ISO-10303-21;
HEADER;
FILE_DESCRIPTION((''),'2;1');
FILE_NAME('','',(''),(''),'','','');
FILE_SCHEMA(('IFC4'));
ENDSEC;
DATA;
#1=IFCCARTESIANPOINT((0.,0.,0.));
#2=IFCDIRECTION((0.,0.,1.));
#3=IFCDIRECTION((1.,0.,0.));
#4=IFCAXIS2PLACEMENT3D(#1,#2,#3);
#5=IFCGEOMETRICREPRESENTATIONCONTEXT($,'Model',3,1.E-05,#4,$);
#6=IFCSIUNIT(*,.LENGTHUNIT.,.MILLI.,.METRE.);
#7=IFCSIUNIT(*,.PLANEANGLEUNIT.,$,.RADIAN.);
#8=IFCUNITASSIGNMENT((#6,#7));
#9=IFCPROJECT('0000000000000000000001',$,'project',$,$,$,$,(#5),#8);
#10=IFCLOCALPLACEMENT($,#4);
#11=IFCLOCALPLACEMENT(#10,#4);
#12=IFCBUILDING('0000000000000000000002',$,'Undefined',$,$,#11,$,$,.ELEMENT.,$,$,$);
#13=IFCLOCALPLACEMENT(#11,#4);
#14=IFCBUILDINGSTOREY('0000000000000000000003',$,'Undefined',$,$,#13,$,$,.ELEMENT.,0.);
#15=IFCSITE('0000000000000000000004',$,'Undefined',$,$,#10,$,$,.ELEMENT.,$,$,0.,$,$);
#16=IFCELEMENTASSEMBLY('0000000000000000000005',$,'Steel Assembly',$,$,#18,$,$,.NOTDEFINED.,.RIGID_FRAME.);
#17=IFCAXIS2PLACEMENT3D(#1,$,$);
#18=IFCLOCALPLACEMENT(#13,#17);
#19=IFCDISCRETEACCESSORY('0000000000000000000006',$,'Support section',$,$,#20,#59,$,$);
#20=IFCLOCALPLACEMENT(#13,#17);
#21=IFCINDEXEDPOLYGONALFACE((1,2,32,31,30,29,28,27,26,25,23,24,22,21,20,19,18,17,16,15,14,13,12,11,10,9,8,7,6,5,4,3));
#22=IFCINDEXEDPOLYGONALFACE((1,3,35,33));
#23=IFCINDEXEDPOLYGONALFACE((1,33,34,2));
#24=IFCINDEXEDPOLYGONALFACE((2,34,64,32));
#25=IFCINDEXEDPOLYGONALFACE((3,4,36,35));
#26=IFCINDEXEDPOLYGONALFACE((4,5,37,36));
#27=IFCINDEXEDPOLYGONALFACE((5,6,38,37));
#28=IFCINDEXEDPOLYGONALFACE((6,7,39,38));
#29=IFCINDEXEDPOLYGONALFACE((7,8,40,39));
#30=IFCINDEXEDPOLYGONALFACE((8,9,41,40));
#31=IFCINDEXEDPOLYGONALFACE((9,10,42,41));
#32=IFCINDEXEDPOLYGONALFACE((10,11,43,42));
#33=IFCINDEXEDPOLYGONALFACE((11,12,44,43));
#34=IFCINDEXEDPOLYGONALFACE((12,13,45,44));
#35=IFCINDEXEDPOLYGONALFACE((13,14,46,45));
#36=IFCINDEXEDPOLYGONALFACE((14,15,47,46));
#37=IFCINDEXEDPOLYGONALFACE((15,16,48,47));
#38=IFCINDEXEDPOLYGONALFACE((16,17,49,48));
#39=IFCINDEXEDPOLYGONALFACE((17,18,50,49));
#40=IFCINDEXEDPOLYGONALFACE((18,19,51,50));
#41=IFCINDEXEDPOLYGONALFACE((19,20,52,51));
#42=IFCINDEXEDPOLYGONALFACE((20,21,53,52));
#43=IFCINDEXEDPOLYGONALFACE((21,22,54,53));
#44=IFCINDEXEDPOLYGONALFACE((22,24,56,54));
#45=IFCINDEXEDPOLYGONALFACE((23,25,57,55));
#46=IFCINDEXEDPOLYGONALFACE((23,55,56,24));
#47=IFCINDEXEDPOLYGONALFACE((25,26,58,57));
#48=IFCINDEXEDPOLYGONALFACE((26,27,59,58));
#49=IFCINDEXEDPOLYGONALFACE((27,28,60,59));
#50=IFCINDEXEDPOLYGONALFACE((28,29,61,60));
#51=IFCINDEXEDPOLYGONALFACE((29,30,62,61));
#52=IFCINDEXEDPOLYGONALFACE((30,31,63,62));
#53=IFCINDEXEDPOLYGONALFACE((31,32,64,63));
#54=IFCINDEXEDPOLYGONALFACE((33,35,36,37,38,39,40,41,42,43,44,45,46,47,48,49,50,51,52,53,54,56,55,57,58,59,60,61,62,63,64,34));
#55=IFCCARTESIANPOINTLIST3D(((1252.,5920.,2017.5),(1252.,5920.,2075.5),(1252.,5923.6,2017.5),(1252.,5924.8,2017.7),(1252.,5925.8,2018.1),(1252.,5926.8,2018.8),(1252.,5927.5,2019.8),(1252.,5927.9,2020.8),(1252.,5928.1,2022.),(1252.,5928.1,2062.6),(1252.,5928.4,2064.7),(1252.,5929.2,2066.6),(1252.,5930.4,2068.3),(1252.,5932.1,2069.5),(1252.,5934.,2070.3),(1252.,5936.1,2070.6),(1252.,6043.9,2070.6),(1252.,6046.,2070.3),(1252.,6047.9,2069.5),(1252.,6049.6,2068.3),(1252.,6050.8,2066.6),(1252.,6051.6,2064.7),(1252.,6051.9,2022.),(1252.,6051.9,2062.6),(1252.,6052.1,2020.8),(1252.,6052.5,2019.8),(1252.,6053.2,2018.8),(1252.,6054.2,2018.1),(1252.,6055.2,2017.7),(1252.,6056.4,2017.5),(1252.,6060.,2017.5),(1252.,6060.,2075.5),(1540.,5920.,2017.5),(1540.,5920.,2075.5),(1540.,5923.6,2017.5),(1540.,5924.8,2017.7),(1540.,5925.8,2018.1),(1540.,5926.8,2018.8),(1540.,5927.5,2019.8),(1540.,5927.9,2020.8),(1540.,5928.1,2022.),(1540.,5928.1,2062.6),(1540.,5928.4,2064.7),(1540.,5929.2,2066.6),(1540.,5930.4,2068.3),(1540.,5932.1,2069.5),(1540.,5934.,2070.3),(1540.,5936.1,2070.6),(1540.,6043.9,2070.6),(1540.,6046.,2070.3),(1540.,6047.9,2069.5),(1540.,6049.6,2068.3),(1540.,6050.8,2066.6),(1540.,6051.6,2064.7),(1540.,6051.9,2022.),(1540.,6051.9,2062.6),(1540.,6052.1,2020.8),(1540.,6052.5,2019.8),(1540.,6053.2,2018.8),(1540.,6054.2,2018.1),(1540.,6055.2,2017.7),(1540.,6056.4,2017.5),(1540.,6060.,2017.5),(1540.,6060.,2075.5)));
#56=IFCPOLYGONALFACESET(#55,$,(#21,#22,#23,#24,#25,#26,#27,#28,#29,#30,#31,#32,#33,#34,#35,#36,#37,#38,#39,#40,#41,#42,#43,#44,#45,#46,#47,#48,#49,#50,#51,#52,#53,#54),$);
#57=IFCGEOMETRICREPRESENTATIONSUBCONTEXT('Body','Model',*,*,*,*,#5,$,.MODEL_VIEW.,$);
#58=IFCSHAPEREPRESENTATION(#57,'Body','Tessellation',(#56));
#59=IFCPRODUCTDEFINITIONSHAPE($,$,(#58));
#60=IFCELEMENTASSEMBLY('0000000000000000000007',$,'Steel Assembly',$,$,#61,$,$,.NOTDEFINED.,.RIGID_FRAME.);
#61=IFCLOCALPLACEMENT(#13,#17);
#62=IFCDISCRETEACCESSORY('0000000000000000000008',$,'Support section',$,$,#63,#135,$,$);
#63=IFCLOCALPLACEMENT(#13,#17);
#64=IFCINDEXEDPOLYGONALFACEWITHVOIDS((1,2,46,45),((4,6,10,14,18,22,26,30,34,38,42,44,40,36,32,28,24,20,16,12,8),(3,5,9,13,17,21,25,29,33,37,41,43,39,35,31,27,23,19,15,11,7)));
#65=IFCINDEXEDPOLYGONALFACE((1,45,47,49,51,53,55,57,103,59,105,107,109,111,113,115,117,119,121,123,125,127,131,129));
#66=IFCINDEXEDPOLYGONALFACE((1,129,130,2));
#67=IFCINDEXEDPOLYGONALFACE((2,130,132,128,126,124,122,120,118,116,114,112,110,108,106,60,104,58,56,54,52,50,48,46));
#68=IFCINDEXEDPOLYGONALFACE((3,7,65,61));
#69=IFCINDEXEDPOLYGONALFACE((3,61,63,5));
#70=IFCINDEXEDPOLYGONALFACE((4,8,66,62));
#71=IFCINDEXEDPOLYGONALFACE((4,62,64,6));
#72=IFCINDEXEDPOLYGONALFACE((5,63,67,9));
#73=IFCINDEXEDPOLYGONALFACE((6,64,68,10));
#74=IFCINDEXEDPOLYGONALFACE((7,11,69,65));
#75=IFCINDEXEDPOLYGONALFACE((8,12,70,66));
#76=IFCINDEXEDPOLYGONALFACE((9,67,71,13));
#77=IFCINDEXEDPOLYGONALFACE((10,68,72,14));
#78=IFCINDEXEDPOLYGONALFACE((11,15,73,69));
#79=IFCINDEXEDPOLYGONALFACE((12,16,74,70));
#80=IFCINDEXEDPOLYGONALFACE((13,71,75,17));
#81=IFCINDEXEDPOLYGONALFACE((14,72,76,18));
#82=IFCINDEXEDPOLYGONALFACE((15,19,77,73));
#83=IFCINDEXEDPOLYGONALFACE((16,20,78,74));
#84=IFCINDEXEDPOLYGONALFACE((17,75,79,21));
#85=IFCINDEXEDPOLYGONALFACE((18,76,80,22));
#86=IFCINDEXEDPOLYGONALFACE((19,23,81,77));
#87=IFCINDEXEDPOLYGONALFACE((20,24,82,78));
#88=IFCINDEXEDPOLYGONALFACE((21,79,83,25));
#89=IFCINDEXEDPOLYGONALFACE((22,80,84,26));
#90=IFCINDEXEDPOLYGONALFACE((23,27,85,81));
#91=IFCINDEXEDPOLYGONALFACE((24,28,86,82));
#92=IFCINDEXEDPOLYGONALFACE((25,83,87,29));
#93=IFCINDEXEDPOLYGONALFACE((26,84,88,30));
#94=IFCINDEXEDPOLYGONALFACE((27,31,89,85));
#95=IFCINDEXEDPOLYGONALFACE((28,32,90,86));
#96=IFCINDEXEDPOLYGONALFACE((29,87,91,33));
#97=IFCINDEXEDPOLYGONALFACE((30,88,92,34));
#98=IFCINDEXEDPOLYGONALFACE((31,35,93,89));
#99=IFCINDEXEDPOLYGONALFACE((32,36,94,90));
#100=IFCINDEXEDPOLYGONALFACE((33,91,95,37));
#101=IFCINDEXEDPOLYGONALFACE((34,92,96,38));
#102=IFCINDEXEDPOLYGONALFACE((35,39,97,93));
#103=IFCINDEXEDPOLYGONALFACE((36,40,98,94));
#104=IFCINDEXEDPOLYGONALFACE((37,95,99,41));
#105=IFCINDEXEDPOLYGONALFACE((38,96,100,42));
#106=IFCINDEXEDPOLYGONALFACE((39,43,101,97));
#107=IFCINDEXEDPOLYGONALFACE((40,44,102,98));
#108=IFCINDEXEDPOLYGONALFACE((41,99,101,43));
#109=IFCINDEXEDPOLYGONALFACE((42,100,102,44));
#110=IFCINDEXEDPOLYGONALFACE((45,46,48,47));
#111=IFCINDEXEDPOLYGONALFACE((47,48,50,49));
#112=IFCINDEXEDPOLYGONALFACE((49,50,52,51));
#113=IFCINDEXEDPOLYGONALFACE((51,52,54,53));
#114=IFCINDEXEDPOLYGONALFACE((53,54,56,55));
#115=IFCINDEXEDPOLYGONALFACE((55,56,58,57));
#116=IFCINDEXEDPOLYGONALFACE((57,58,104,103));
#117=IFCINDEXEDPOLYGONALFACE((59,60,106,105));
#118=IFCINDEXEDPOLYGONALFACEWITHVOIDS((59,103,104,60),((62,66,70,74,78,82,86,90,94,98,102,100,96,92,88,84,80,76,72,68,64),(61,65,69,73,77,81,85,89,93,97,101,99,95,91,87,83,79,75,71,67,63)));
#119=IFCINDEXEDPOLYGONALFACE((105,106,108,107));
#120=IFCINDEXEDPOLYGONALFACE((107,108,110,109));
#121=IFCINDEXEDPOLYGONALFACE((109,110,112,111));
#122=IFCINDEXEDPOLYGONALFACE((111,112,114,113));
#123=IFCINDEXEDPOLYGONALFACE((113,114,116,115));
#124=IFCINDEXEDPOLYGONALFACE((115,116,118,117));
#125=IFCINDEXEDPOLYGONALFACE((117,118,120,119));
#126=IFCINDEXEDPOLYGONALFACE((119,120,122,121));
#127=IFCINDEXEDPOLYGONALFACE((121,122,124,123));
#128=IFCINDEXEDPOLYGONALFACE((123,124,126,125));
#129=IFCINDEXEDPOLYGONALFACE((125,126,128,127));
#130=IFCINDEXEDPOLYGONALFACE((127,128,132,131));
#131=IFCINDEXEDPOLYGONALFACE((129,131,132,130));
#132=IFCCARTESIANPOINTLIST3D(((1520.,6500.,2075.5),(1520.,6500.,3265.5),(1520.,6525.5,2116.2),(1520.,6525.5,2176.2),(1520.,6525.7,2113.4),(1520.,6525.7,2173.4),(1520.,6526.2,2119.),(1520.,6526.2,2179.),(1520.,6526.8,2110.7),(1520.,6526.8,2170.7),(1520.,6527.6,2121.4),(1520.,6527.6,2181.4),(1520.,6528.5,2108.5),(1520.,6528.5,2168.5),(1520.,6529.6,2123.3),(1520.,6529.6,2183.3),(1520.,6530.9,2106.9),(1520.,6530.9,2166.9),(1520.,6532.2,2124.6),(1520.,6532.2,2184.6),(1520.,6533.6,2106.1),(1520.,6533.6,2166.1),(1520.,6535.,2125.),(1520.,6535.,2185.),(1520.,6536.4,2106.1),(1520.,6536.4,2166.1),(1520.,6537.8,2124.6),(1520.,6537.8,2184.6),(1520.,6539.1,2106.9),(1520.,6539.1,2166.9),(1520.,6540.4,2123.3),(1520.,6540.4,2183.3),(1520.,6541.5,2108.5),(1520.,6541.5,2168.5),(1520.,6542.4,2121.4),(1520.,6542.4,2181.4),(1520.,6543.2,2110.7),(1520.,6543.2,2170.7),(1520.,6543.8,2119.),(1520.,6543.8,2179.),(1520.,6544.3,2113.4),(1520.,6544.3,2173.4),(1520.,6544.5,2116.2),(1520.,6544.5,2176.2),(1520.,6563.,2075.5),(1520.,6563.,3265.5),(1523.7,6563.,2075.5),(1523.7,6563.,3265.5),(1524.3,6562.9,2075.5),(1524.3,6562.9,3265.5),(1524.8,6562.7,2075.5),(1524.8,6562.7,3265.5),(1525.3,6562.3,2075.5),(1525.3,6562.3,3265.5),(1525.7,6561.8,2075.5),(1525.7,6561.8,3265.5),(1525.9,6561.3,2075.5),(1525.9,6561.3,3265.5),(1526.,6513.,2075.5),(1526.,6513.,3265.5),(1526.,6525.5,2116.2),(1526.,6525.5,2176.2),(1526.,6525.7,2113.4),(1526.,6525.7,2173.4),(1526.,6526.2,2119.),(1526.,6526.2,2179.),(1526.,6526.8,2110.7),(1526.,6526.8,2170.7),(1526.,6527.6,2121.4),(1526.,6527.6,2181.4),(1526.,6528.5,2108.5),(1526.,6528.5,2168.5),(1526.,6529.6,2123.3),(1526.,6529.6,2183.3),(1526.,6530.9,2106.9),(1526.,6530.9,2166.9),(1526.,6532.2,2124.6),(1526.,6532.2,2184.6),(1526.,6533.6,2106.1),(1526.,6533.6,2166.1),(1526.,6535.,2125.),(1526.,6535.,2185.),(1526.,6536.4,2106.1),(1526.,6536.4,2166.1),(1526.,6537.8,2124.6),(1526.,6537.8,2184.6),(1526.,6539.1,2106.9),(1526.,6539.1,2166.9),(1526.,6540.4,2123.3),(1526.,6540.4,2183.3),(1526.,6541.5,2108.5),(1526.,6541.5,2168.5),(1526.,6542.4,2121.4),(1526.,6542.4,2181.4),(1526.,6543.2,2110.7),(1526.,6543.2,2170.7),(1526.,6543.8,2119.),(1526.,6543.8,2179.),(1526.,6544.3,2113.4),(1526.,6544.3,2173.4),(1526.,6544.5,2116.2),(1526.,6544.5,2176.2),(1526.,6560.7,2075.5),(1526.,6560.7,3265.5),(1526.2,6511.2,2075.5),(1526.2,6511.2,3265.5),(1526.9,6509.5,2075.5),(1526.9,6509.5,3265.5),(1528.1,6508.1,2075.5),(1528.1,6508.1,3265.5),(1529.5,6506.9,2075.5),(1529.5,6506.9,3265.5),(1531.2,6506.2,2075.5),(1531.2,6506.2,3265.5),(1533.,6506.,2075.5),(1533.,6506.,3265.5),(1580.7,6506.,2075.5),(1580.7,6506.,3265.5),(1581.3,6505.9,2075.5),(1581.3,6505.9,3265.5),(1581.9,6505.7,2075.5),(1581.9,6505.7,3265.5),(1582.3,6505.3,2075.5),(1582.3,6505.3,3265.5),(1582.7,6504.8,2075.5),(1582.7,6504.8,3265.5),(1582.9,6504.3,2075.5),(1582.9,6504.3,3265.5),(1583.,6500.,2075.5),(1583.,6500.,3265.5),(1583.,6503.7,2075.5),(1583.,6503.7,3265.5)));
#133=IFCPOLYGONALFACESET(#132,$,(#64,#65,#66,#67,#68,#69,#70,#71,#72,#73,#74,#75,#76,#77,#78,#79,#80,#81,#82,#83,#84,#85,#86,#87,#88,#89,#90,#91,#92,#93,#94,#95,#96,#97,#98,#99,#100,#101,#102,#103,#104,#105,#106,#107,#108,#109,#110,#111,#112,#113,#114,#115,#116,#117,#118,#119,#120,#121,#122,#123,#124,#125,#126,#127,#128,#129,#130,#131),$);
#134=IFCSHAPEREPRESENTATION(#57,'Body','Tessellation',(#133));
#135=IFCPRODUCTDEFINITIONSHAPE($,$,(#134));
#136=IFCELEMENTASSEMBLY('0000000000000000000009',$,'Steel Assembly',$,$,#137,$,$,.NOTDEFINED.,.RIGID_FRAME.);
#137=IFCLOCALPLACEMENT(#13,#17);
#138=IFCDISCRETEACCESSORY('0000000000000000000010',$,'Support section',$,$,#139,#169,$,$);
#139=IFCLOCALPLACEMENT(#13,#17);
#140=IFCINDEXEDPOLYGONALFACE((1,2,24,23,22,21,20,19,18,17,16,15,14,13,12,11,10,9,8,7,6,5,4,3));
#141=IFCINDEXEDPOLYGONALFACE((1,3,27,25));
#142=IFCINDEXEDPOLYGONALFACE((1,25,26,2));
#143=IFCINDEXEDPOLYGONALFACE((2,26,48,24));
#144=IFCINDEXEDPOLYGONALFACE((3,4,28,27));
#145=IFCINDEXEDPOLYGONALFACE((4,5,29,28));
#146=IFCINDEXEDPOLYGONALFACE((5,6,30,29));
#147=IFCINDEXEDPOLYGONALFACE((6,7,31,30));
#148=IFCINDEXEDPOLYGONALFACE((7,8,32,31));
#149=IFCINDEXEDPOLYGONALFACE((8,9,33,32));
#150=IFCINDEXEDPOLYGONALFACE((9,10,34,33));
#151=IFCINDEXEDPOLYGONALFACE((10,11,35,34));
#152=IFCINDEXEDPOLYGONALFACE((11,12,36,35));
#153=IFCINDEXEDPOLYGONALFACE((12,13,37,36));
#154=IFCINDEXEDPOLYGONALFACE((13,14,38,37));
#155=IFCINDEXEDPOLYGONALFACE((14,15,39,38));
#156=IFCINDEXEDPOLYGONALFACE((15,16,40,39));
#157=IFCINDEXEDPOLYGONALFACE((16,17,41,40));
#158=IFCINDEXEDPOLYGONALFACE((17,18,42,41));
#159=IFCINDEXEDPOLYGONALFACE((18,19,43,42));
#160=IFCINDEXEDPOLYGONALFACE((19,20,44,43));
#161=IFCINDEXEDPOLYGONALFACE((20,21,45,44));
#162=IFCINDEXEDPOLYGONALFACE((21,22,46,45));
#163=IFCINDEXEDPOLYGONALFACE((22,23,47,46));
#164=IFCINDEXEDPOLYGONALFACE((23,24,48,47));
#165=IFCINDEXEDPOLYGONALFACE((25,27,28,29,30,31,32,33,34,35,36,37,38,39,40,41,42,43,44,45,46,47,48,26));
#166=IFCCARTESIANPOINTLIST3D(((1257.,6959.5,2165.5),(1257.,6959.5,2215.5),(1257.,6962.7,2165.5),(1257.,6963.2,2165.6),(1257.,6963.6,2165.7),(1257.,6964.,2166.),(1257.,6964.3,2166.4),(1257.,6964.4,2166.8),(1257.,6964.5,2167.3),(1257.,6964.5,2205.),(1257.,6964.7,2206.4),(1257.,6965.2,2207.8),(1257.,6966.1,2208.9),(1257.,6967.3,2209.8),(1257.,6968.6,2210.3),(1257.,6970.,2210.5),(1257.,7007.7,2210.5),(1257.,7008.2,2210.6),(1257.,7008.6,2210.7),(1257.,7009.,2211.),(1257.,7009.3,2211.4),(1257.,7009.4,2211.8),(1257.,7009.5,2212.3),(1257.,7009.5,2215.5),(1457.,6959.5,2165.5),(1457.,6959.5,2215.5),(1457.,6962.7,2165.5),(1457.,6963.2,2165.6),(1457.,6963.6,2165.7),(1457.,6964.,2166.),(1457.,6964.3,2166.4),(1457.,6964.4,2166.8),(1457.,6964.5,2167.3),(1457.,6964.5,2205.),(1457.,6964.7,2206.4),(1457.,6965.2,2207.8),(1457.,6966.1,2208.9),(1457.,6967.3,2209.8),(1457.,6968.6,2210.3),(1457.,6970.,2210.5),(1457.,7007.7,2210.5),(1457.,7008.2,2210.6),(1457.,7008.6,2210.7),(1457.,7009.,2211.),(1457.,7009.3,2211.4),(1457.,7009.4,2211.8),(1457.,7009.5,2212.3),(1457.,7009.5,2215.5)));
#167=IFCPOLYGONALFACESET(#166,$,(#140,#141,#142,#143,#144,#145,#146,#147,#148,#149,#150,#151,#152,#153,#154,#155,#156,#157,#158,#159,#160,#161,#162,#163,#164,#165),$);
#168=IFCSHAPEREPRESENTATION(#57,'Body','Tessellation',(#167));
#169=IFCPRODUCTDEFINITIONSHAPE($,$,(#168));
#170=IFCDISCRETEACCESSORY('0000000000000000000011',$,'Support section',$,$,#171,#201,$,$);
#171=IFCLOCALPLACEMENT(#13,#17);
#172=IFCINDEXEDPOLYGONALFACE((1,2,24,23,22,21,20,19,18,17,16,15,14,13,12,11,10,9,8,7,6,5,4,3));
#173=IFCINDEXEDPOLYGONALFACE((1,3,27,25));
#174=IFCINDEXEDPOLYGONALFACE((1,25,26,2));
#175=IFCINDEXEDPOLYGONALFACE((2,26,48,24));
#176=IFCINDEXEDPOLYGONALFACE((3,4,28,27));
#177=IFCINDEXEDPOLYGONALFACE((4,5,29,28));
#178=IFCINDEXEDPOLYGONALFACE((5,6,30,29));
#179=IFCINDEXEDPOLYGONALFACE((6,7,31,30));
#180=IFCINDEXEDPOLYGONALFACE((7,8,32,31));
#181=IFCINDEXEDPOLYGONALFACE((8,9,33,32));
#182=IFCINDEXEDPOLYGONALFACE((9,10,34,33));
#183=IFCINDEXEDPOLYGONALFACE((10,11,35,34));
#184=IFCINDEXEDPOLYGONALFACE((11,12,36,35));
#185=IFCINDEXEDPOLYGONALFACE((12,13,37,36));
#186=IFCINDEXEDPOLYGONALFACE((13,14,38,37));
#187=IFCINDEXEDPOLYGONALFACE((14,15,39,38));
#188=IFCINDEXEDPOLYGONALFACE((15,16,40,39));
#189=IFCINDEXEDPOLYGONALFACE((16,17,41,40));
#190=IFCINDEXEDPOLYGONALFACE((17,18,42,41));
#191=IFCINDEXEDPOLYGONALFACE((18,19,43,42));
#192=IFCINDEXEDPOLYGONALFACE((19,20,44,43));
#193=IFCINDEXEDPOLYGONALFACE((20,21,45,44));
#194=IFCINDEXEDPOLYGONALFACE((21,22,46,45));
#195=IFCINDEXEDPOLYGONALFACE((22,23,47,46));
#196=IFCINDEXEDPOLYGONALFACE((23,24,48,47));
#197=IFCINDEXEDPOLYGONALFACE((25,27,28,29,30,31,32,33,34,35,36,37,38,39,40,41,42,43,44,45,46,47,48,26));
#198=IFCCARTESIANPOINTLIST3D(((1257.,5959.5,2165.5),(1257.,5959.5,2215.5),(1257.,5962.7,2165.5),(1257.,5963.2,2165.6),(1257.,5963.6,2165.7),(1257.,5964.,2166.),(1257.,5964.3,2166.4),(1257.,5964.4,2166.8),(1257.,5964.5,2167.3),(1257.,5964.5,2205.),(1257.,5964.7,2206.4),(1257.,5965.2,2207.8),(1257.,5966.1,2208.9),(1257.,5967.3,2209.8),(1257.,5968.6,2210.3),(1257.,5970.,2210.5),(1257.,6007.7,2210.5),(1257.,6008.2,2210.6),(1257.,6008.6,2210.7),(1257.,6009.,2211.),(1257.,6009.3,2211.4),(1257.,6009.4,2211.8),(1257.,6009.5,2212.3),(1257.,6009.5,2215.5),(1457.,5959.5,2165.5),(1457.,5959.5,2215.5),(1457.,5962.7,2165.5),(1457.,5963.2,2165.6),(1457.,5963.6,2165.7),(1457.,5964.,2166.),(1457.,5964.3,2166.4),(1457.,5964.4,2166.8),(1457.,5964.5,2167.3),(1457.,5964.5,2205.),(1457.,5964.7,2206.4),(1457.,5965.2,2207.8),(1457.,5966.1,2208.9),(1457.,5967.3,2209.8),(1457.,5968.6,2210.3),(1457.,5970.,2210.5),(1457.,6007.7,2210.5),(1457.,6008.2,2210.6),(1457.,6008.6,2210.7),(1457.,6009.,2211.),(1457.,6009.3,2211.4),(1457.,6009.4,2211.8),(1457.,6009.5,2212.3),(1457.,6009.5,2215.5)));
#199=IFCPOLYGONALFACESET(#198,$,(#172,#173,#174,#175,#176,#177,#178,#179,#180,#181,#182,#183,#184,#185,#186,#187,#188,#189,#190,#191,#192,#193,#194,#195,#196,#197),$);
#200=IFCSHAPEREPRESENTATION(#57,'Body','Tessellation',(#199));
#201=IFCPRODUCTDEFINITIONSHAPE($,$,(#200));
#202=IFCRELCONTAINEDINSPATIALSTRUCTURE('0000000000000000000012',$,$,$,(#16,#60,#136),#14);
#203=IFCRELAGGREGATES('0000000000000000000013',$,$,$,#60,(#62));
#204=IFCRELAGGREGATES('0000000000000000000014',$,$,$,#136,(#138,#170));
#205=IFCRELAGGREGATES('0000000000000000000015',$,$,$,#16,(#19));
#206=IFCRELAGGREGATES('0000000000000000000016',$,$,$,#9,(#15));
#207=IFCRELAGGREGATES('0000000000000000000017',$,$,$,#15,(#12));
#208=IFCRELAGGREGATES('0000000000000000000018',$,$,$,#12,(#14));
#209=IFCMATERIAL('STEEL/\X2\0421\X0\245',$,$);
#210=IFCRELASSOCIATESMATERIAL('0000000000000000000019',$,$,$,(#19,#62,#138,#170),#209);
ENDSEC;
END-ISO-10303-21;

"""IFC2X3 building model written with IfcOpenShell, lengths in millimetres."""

from ifc_helpers import new_model, si_unit, frame, origin_with_axes, origin_2d_with_axis, place, context, subcontext, project, spatial, circle, l_section, u_section, extrude, source, transform, mapped, material, element, aggregate, save


model = new_model("IFC2X3")

# Units and contexts
model_context = context("Model", 3, precision=1e-05, world=origin_with_axes())
body_context = subcontext(model_context, "Body", "Model", "MODEL_VIEW")
ifc_project = project(units=[si_unit("LENGTHUNIT", "METRE", prefix="MILLI"), si_unit("PLANEANGLEUNIT", "RADIAN")], contexts=[model_context])

# Site, building, storey
site_placement = place(None, origin_with_axes())
site = spatial("IfcSite", under=ifc_project, at=site_placement, Name="Undefined", CompositionType="ELEMENT", RefElevation=0.0)
building_placement = place(site_placement, origin_with_axes())
building = spatial("IfcBuilding", under=site, at=building_placement, Name="Undefined", CompositionType="ELEMENT")
storey_placement = place(building_placement, origin_with_axes())
storey = spatial("IfcBuildingStorey", under=building, at=storey_placement, Name="Undefined", CompositionType="ELEMENT", Elevation=0.0)

# Shared definitions
ifc_material_1 = material(Name="STEEL/С245")

# Element assembly, discrete accessory
assembly_1_placement = place(storey_placement, origin_with_axes())
assembly_1 = element("IfcElementAssembly", 1, at=assembly_1_placement, inside=storey, Name="Steel Assembly", AssemblyPlace="NOTDEFINED", PredefinedType="RIGID_FRAME")
discrete_accessory_1_placement = place(assembly_1_placement, frame((1252.0, 5990.0, 2046.5), z_axis=(0.0, -1.0, 0.0), x_axis=(1.0, 0.0, 0.0)))
discrete_accessory_1 = element("IfcDiscreteAccessory", 2, at=discrete_accessory_1_placement, material=ifc_material_1, Name="Support section", context=body_context, shape_type="SweptSolid", body=[
    extrude(u_section(Depth=140.0, FlangeWidth=58.0, WebThickness=4.9, FlangeThickness=8.1, FilletRadius=8.0, EdgeRadius=4.5, at=origin_2d_with_axis()), frame((288.0, 0.0, 0.0), z_axis=(-1.0, 0.0, 0.0), x_axis=(0.0, -1.0, 0.0)), (0.0, 0.0, 1.0), 288.0),
])

# Element assembly, discrete accessory, opening
assembly_2_placement = place(storey_placement, origin_with_axes())
assembly_2 = element("IfcElementAssembly", 3, at=assembly_2_placement, inside=storey, Name="Steel Assembly", AssemblyPlace="NOTDEFINED", PredefinedType="RIGID_FRAME")
discrete_accessory_2_placement = place(assembly_2_placement, frame((1551.5, 6531.5, 2075.5), z_axis=(0.0, 0.0, 1.0), x_axis=(1.0, 0.0, 0.0)))
discrete_accessory_2 = element("IfcDiscreteAccessory", 4, at=discrete_accessory_2_placement, material=ifc_material_1, Name="Support section", context=body_context, shape_type="SweptSolid", body=[
    extrude(l_section(Depth=63.0, Width=63.0, Thickness=6.0, FilletRadius=7.0, EdgeRadius=2.3, at=origin_2d_with_axis()), frame((0.0, 0.0, 1190.0), z_axis=(0.0, 0.0, -1.0), x_axis=(0.0, 1.0, 0.0)), (0.0, 0.0, 1.0), 1190.0),
])
shared_shape_1 = source(origin_with_axes(), body_context, "Body", "SweptSolid", [
    extrude(circle(Radius=9.5, at=origin_2d_with_axis()), frame((0.0, -0.1, 0.0), z_axis=(0.0, 1.0, 0.0), x_axis=(1.0, 0.0, 0.0)), (0.0, 0.0, 1.0), 6.2),
])
opening_1_placement = place(assembly_2_placement, frame((1520.0, 6535.0, 2115.5), z_axis=(0.0, 1.0, 0.0), x_axis=(0.0, 0.0, 1.0)))
element("IfcOpeningElement", 5, at=opening_1_placement, cuts=discrete_accessory_2, ObjectType="Opening", context=body_context, shape_type="MappedRepresentation", body=[
    mapped(shared_shape_1, transform((0.0, 0.0, 0.0))),
    mapped(shared_shape_1, transform((60.0, 0.0, 0.0))),
])
aggregate(assembly_2, [discrete_accessory_2])

# Element assembly, discrete accessories
assembly_3_placement = place(storey_placement, origin_with_axes())
assembly_3 = element("IfcElementAssembly", 6, at=assembly_3_placement, inside=storey, Name="Steel Assembly", AssemblyPlace="NOTDEFINED", PredefinedType="RIGID_FRAME")
discrete_accessory_3_placement = place(assembly_3_placement, frame((1457.0, 6984.5, 2190.5), z_axis=(0.0, 1.0, 0.0), x_axis=(-1.0, 0.0, 0.0)))
discrete_accessory_3 = element("IfcDiscreteAccessory", 7, at=discrete_accessory_3_placement, material=ifc_material_1, Name="Support section", context=body_context, shape_type="SweptSolid", body=[
    extrude(l_section(Depth=50.0, Width=50.0, Thickness=5.0, FilletRadius=5.5, EdgeRadius=1.8, at=origin_2d_with_axis()), frame((200.0, 0.0, 0.0), z_axis=(-1.0, 0.0, 0.0), x_axis=(0.0, -1.0, 0.0)), (0.0, 0.0, 1.0), 200.0),
])
discrete_accessory_4_placement = place(assembly_3_placement, frame((1457.0, 5984.5, 2190.5), z_axis=(0.0, 1.0, 0.0), x_axis=(-1.0, 0.0, 0.0)))
discrete_accessory_4 = element("IfcDiscreteAccessory", 8, at=discrete_accessory_4_placement, material=ifc_material_1, Name="Support section", context=body_context, shape_type="SweptSolid", body=[
    extrude(l_section(Depth=50.0, Width=50.0, Thickness=5.0, FilletRadius=5.5, EdgeRadius=1.8, at=origin_2d_with_axis()), frame((200.0, 0.0, 0.0), z_axis=(-1.0, 0.0, 0.0), x_axis=(0.0, -1.0, 0.0)), (0.0, 0.0, 1.0), 200.0),
])
aggregate(assembly_3, [discrete_accessory_3, discrete_accessory_4])

aggregate(assembly_1, [discrete_accessory_1])

save(model, "model.ifc")
